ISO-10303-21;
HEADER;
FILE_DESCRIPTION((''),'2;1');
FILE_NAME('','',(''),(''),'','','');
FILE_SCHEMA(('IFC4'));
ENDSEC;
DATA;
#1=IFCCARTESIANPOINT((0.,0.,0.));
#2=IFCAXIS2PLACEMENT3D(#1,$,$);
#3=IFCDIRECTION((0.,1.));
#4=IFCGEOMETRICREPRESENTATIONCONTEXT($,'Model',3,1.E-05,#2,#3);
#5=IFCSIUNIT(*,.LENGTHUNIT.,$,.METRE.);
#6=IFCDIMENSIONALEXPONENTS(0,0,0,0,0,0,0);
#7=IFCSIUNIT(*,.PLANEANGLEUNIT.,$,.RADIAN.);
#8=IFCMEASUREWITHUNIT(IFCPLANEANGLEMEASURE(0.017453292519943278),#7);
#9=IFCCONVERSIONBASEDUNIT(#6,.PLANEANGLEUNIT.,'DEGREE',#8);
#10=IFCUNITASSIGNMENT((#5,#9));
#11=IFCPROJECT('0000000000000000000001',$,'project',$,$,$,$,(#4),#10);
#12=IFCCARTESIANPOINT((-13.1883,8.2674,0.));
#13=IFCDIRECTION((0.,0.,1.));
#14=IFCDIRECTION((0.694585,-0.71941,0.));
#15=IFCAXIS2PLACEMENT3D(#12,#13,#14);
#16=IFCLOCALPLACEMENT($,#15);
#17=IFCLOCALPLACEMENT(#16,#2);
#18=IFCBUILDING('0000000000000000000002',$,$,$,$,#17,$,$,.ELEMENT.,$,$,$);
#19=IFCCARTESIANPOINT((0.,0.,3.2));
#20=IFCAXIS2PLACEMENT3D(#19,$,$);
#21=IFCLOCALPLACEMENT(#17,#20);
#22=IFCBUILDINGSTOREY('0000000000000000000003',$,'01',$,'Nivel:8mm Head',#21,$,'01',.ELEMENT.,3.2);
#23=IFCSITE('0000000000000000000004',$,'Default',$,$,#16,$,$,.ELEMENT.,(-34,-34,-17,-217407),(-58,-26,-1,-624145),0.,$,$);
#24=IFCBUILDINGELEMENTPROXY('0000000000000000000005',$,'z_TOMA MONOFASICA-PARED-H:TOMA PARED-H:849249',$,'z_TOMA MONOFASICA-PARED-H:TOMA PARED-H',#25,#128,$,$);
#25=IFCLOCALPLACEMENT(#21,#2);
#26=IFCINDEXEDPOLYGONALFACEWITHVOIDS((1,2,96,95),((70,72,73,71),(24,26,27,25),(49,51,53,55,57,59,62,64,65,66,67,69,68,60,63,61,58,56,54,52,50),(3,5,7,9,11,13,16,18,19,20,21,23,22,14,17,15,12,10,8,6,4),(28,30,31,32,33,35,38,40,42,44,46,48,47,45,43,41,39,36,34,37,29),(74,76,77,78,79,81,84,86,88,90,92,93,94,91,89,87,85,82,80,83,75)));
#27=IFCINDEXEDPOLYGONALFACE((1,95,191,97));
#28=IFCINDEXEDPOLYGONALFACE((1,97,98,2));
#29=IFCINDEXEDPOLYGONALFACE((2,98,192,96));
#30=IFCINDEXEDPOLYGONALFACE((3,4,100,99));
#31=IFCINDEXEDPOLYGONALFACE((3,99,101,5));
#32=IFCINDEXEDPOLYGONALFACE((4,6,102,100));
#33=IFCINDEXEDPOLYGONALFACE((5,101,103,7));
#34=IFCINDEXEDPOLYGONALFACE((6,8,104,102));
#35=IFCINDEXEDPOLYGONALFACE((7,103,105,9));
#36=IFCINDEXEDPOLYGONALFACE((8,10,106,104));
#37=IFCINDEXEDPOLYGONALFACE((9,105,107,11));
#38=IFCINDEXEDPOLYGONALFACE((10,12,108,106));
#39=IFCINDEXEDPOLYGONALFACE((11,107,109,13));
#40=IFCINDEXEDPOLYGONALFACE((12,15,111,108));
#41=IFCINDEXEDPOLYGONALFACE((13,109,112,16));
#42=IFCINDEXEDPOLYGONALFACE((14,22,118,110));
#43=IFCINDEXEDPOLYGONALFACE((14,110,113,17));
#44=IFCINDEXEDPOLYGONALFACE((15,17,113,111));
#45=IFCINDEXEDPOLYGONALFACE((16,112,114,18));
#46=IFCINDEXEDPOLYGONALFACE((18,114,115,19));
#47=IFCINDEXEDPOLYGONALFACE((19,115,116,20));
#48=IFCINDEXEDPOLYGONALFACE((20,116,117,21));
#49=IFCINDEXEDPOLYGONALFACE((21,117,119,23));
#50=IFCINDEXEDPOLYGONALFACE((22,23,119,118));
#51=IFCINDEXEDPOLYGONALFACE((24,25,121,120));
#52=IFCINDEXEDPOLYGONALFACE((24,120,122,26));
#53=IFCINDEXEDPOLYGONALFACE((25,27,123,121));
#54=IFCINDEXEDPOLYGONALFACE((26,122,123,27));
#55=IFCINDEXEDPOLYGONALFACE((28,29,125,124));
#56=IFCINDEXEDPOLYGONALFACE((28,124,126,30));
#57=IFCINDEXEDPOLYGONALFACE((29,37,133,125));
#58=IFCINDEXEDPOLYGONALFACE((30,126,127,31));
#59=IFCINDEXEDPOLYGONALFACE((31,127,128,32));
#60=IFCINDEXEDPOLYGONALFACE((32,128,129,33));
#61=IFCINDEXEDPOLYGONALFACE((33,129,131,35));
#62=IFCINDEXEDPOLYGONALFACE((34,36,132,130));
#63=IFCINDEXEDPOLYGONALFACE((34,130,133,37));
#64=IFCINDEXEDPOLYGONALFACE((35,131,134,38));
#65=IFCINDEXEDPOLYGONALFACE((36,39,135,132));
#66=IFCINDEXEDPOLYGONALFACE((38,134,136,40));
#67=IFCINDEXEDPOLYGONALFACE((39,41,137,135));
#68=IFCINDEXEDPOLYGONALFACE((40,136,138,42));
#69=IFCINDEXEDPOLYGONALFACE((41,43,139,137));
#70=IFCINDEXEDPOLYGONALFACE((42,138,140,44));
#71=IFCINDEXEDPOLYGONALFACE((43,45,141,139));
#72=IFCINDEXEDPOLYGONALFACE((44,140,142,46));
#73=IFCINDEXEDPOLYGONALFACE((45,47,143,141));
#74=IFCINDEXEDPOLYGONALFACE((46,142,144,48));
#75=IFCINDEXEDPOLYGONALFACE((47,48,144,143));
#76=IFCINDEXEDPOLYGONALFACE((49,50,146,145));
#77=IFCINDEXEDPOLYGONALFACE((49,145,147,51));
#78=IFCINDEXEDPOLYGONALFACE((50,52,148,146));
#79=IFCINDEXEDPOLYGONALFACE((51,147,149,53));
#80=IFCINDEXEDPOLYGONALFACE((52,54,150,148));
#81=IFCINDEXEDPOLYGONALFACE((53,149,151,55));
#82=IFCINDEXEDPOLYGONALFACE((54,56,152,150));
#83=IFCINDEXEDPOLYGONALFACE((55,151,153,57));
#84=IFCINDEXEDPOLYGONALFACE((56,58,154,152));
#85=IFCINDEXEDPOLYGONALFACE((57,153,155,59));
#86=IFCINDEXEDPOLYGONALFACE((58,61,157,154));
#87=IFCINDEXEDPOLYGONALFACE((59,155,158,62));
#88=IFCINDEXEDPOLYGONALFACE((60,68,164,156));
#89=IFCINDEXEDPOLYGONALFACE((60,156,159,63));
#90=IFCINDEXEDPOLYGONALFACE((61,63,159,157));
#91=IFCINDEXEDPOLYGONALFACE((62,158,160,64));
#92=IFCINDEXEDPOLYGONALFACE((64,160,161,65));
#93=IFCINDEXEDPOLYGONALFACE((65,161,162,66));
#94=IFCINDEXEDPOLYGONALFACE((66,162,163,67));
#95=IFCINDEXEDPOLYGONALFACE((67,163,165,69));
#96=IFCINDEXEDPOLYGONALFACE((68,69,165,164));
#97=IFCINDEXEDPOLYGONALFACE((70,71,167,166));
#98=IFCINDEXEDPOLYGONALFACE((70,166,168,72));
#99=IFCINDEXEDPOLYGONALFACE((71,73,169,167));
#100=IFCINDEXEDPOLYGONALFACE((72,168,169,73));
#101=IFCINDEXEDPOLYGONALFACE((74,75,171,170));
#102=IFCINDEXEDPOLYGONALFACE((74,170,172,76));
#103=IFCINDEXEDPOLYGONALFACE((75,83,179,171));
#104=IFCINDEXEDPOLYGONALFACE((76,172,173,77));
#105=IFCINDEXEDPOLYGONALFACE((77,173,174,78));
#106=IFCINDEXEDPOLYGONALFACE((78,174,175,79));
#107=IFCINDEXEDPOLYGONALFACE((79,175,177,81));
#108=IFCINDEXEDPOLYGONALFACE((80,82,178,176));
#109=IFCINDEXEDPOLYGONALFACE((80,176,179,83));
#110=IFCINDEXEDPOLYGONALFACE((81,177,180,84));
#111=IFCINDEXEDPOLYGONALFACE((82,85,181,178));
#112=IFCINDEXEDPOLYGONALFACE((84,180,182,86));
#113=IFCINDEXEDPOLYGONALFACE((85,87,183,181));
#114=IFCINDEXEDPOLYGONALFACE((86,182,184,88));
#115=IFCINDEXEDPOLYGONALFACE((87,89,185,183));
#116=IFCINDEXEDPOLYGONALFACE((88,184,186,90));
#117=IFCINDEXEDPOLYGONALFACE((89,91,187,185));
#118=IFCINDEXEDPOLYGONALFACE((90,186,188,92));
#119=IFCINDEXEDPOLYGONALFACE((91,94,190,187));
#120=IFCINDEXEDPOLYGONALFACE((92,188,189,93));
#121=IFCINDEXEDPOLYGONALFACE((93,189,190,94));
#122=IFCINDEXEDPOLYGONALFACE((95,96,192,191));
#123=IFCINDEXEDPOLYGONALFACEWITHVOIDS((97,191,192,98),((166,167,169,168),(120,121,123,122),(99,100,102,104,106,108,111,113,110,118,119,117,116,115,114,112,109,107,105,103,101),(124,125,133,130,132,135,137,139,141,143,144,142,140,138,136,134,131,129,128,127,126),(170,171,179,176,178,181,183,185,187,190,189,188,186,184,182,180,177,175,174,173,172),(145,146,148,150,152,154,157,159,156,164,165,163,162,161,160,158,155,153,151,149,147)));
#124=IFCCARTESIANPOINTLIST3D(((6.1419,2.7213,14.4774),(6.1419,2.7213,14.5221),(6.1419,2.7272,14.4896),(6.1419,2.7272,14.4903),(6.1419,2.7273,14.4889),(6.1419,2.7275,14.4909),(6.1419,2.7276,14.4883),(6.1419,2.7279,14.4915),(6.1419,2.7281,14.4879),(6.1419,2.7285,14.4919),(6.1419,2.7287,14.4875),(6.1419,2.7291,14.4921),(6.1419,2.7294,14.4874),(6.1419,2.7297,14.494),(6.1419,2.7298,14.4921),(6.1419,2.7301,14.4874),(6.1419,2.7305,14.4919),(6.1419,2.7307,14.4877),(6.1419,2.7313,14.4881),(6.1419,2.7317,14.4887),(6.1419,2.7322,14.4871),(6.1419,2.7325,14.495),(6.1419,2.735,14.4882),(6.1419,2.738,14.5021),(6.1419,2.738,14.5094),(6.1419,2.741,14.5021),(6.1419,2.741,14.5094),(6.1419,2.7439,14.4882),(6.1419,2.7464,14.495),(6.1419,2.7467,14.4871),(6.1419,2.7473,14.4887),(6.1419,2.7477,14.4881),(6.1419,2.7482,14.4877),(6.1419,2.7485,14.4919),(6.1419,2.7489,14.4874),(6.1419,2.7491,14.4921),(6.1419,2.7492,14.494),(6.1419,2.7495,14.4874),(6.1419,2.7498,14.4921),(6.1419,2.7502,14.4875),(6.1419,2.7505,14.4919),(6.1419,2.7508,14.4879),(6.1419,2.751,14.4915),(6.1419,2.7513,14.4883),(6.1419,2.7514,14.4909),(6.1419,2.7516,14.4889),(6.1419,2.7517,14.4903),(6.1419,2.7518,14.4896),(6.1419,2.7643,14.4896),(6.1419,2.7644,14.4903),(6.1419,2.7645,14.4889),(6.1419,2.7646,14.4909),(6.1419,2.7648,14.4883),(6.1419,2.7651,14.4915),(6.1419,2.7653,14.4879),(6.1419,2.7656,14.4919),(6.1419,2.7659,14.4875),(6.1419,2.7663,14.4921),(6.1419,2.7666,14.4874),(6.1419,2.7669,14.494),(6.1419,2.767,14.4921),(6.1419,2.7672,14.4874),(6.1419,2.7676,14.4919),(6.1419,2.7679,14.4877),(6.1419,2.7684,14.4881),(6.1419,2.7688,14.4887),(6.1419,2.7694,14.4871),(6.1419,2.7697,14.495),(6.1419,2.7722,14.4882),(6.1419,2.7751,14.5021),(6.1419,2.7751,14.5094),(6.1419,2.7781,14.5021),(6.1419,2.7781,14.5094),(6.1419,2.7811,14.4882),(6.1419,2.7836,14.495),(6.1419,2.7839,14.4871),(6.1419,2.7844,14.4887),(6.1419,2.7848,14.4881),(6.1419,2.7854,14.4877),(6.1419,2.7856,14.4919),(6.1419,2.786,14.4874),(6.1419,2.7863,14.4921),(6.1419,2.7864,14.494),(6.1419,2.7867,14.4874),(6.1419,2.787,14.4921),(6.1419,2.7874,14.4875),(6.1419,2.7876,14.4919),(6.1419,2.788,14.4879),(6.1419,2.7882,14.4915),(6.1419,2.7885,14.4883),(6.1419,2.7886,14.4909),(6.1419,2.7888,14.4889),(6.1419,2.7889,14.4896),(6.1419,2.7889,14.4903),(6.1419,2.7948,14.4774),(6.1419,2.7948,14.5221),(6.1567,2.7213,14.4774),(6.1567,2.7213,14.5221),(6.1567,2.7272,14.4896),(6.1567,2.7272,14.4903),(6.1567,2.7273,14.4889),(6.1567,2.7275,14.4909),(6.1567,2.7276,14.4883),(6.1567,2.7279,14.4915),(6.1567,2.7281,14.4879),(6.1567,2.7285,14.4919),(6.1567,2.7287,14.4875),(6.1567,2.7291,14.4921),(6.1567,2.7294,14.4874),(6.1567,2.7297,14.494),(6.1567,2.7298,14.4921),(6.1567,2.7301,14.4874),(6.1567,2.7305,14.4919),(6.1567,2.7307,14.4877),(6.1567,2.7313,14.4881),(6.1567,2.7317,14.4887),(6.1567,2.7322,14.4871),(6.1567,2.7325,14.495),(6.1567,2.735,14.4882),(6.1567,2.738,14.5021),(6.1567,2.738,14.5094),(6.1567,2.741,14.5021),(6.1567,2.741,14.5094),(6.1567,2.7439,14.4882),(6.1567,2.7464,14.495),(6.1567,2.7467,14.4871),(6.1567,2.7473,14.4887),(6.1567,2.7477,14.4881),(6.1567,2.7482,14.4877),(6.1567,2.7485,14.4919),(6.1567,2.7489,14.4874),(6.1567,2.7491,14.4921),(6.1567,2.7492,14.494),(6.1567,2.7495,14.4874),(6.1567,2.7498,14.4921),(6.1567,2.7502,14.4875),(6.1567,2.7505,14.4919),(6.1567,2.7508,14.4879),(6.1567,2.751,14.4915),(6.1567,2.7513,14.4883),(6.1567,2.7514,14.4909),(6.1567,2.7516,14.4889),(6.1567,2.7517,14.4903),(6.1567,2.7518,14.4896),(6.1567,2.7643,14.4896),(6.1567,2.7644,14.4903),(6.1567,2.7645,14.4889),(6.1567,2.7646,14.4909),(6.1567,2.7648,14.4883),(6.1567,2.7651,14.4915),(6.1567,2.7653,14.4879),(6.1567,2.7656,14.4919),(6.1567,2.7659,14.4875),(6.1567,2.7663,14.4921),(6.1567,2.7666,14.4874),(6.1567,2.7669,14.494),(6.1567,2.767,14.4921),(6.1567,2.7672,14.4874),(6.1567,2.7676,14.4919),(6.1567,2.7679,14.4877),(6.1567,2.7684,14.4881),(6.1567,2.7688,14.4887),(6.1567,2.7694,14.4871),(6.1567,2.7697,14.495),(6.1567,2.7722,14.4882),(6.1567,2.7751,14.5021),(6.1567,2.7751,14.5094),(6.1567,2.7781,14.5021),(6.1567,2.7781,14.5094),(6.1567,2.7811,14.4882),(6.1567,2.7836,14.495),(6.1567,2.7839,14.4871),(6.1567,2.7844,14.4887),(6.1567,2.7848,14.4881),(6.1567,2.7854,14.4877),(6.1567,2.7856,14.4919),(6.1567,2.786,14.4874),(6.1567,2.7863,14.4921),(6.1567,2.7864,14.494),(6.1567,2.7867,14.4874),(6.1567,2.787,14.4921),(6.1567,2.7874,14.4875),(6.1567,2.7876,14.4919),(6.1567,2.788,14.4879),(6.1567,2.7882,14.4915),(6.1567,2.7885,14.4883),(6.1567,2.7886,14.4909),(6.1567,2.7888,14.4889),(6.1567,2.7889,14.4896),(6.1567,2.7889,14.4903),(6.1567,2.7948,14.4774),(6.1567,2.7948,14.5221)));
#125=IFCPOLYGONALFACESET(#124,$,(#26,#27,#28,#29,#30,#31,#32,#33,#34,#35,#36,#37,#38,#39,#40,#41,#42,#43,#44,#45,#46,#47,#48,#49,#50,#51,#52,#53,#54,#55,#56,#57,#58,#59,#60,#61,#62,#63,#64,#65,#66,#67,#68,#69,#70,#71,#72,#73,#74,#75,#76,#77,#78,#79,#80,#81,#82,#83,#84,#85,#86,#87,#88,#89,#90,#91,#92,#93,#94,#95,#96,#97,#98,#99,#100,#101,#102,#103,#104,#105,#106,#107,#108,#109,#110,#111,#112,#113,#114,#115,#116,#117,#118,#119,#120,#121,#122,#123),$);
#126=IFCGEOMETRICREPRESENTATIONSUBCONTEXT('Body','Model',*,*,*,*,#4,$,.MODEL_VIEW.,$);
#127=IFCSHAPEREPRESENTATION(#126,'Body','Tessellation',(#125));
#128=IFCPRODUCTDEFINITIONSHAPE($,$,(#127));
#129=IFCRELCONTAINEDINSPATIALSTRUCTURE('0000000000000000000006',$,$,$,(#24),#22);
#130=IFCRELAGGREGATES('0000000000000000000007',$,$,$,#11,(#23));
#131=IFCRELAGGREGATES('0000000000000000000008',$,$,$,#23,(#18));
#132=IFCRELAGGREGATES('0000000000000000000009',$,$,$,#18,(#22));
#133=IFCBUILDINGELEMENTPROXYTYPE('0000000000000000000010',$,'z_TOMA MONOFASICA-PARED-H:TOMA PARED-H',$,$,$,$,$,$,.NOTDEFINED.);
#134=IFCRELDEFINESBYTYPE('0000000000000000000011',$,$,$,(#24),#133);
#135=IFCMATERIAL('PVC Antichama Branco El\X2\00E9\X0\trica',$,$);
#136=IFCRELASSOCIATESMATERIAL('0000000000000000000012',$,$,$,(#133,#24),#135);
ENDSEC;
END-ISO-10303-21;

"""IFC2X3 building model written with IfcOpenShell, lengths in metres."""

from ifc_helpers import new_model, entity, si_unit, converted_unit, direction, frame, frame_2d, origin, place, context, subcontext, project, spatial, polyline, circle_curve, parameter, trimmed, segment, composite_curve, outline, extrude, source, transform, mapped, material, type_object, type_shapes, element, save


model = new_model("IFC2X3")

# Units and contexts
model_context = context("Model", 3, precision=1e-05, world=origin(), true_north=direction((0.0, 1.0)))
body_context = subcontext(model_context, "Body", "Model", "MODEL_VIEW")
ifc_project = project(units=[si_unit("LENGTHUNIT", "METRE"), converted_unit("PLANEANGLEUNIT", "DEGREE", entity("IfcPlaneAngleMeasure", 0.017453292519943278), si_unit("PLANEANGLEUNIT", "RADIAN"), dimensions=[0, 0, 0, 0, 0, 0, 0])], contexts=[model_context])

# Site, building, storey
site_placement = place(None, frame((-13.1883, 8.2674, 0.0), z_axis=(0.0, 0.0, 1.0), x_axis=(0.694585, -0.71941, 0.0)))
site = spatial("IfcSite", under=ifc_project, at=site_placement, Name="Default", CompositionType="ELEMENT", RefLatitude=(-34, -34, -17, -217407), RefLongitude=(-58, -26, -1, -624145), RefElevation=0.0)
building_placement = place(site_placement, origin())
building = spatial("IfcBuilding", under=site, at=building_placement, CompositionType="ELEMENT")
storey_placement = place(building_placement, frame((0.0, 0.0, 3.2)))
storey = spatial("IfcBuildingStorey", under=building, at=storey_placement, Name="01", ObjectType="Nivel:8mm Head", LongName="01", CompositionType="ELEMENT", Elevation=3.2)

# Building element proxy
ifc_material_1 = material(Name="PVC Antichama Branco Elétrica")
building_element_proxy_type_1 = type_object("IfcBuildingElementProxyType", Name="z_TOMA MONOFASICA-PARED-H:TOMA PARED-H", PredefinedType="NOTDEFINED", material=ifc_material_1)
shared_shape_1 = source(origin(), body_context, "Body", "SweptSolid", [
    extrude(outline(polyline([(-0.0368, -0.0223), (0.0368, -0.0223), (0.0368, 0.0223), (-0.0368, 0.0223), (-0.0368, -0.0223)]), holes=[composite_curve([segment(polyline([(0.0141, 0.0115), (0.0116, 0.0047)]), True, "CONTINUOUS"), segment(polyline([(0.0116, 0.0047), (0.0088, 0.0057)]), True, "CONTINUOUS"), segment(polyline([(0.0088, 0.0057), (0.0096, 0.0078)]), True, "CONTINUOUS"), segment(trimmed(circle_curve(frame_2d((0.0087, 0.0099), x_axis=(1.0, 0.0)), 0.0024), [parameter(27.118901)], [parameter(292.881099)], True, "PARAMETER"), False, "CONTINUOUS"), segment(polyline([(0.0108, 0.011), (0.0113, 0.0126)]), True, "CONTINUOUS"), segment(polyline([(0.0113, 0.0126), (0.0141, 0.0115)]), True, "CONTINUOUS")], self_intersect=False), composite_curve([segment(polyline([(0.0255, 0.0047), (0.023, 0.0115)]), True, "CONTINUOUS"), segment(polyline([(0.023, 0.0115), (0.0258, 0.0126)]), True, "CONTINUOUS"), segment(polyline([(0.0258, 0.0126), (0.0264, 0.011)]), True, "CONTINUOUS"), segment(trimmed(circle_curve(frame_2d((0.0285, 0.0099), x_axis=(1.0, 0.0)), 0.0024), [parameter(247.118901)], [parameter(152.881099)], True, "PARAMETER"), False, "CONTINUOUS"), segment(polyline([(0.0276, 0.0078), (0.0283, 0.0057)]), True, "CONTINUOUS"), segment(polyline([(0.0283, 0.0057), (0.0255, 0.0047)]), True, "CONTINUOUS")], self_intersect=False), polyline([(0.0201, -0.0024), (0.0201, -0.0097), (0.0171, -0.0097), (0.0171, -0.0024), (0.0201, -0.0024)]), composite_curve([segment(polyline([(-0.0141, 0.0115), (-0.0113, 0.0126)]), True, "CONTINUOUS"), segment(polyline([(-0.0113, 0.0126), (-0.0108, 0.011)]), True, "CONTINUOUS"), segment(trimmed(circle_curve(frame_2d((-0.0087, 0.0099), x_axis=(1.0, 0.0)), 0.0024), [parameter(247.118901)], [parameter(152.881099)], True, "PARAMETER"), False, "CONTINUOUS"), segment(polyline([(-0.0096, 0.0078), (-0.0088, 0.0057)]), True, "CONTINUOUS"), segment(polyline([(-0.0088, 0.0057), (-0.0116, 0.0047)]), True, "CONTINUOUS"), segment(polyline([(-0.0116, 0.0047), (-0.0141, 0.0115)]), True, "CONTINUOUS")], self_intersect=False), composite_curve([segment(polyline([(-0.0255, 0.0047), (-0.0283, 0.0057)]), True, "CONTINUOUS"), segment(polyline([(-0.0283, 0.0057), (-0.0276, 0.0078)]), True, "CONTINUOUS"), segment(trimmed(circle_curve(frame_2d((-0.0285, 0.0099), x_axis=(1.0, 0.0)), 0.0024), [parameter(27.118901)], [parameter(292.881099)], True, "PARAMETER"), False, "CONTINUOUS"), segment(polyline([(-0.0264, 0.011), (-0.0258, 0.0126)]), True, "CONTINUOUS"), segment(polyline([(-0.0258, 0.0126), (-0.023, 0.0115)]), True, "CONTINUOUS"), segment(polyline([(-0.023, 0.0115), (-0.0255, 0.0047)]), True, "CONTINUOUS")], self_intersect=False), polyline([(-0.0201, -0.0024), (-0.0171, -0.0024), (-0.0171, -0.0097), (-0.0201, -0.0097), (-0.0201, -0.0024)])]), frame((0.0, -0.005, 0.0223), z_axis=(0.0, 1.0, 0.0), x_axis=(1.0, 0.0, 0.0)), (0.0, 0.0, 1.0), 0.0148),
])
type_shapes(building_element_proxy_type_1, [shared_shape_1])
for number, where, z_axis, x_axis, name in (
    (1, (6.1469, 2.758, 14.4774), (0.0, 0.0, 1.0), (0.0, -1.0, 0.0), "z_TOMA MONOFASICA-PARED-H:TOMA PARED-H:849249"),
):
    element("IfcBuildingElementProxy", number, at=place(storey_placement, frame(where, z_axis=z_axis, x_axis=x_axis)), inside=storey, type_object=building_element_proxy_type_1, material=ifc_material_1, Name=name, ObjectType="z_TOMA MONOFASICA-PARED-H:TOMA PARED-H", context=body_context, shape_type="MappedRepresentation", body=[
        mapped(shared_shape_1, transform((0.0, 0.0, 0.0), scale=1.0)),
    ])

save(model, "model.ifc")
